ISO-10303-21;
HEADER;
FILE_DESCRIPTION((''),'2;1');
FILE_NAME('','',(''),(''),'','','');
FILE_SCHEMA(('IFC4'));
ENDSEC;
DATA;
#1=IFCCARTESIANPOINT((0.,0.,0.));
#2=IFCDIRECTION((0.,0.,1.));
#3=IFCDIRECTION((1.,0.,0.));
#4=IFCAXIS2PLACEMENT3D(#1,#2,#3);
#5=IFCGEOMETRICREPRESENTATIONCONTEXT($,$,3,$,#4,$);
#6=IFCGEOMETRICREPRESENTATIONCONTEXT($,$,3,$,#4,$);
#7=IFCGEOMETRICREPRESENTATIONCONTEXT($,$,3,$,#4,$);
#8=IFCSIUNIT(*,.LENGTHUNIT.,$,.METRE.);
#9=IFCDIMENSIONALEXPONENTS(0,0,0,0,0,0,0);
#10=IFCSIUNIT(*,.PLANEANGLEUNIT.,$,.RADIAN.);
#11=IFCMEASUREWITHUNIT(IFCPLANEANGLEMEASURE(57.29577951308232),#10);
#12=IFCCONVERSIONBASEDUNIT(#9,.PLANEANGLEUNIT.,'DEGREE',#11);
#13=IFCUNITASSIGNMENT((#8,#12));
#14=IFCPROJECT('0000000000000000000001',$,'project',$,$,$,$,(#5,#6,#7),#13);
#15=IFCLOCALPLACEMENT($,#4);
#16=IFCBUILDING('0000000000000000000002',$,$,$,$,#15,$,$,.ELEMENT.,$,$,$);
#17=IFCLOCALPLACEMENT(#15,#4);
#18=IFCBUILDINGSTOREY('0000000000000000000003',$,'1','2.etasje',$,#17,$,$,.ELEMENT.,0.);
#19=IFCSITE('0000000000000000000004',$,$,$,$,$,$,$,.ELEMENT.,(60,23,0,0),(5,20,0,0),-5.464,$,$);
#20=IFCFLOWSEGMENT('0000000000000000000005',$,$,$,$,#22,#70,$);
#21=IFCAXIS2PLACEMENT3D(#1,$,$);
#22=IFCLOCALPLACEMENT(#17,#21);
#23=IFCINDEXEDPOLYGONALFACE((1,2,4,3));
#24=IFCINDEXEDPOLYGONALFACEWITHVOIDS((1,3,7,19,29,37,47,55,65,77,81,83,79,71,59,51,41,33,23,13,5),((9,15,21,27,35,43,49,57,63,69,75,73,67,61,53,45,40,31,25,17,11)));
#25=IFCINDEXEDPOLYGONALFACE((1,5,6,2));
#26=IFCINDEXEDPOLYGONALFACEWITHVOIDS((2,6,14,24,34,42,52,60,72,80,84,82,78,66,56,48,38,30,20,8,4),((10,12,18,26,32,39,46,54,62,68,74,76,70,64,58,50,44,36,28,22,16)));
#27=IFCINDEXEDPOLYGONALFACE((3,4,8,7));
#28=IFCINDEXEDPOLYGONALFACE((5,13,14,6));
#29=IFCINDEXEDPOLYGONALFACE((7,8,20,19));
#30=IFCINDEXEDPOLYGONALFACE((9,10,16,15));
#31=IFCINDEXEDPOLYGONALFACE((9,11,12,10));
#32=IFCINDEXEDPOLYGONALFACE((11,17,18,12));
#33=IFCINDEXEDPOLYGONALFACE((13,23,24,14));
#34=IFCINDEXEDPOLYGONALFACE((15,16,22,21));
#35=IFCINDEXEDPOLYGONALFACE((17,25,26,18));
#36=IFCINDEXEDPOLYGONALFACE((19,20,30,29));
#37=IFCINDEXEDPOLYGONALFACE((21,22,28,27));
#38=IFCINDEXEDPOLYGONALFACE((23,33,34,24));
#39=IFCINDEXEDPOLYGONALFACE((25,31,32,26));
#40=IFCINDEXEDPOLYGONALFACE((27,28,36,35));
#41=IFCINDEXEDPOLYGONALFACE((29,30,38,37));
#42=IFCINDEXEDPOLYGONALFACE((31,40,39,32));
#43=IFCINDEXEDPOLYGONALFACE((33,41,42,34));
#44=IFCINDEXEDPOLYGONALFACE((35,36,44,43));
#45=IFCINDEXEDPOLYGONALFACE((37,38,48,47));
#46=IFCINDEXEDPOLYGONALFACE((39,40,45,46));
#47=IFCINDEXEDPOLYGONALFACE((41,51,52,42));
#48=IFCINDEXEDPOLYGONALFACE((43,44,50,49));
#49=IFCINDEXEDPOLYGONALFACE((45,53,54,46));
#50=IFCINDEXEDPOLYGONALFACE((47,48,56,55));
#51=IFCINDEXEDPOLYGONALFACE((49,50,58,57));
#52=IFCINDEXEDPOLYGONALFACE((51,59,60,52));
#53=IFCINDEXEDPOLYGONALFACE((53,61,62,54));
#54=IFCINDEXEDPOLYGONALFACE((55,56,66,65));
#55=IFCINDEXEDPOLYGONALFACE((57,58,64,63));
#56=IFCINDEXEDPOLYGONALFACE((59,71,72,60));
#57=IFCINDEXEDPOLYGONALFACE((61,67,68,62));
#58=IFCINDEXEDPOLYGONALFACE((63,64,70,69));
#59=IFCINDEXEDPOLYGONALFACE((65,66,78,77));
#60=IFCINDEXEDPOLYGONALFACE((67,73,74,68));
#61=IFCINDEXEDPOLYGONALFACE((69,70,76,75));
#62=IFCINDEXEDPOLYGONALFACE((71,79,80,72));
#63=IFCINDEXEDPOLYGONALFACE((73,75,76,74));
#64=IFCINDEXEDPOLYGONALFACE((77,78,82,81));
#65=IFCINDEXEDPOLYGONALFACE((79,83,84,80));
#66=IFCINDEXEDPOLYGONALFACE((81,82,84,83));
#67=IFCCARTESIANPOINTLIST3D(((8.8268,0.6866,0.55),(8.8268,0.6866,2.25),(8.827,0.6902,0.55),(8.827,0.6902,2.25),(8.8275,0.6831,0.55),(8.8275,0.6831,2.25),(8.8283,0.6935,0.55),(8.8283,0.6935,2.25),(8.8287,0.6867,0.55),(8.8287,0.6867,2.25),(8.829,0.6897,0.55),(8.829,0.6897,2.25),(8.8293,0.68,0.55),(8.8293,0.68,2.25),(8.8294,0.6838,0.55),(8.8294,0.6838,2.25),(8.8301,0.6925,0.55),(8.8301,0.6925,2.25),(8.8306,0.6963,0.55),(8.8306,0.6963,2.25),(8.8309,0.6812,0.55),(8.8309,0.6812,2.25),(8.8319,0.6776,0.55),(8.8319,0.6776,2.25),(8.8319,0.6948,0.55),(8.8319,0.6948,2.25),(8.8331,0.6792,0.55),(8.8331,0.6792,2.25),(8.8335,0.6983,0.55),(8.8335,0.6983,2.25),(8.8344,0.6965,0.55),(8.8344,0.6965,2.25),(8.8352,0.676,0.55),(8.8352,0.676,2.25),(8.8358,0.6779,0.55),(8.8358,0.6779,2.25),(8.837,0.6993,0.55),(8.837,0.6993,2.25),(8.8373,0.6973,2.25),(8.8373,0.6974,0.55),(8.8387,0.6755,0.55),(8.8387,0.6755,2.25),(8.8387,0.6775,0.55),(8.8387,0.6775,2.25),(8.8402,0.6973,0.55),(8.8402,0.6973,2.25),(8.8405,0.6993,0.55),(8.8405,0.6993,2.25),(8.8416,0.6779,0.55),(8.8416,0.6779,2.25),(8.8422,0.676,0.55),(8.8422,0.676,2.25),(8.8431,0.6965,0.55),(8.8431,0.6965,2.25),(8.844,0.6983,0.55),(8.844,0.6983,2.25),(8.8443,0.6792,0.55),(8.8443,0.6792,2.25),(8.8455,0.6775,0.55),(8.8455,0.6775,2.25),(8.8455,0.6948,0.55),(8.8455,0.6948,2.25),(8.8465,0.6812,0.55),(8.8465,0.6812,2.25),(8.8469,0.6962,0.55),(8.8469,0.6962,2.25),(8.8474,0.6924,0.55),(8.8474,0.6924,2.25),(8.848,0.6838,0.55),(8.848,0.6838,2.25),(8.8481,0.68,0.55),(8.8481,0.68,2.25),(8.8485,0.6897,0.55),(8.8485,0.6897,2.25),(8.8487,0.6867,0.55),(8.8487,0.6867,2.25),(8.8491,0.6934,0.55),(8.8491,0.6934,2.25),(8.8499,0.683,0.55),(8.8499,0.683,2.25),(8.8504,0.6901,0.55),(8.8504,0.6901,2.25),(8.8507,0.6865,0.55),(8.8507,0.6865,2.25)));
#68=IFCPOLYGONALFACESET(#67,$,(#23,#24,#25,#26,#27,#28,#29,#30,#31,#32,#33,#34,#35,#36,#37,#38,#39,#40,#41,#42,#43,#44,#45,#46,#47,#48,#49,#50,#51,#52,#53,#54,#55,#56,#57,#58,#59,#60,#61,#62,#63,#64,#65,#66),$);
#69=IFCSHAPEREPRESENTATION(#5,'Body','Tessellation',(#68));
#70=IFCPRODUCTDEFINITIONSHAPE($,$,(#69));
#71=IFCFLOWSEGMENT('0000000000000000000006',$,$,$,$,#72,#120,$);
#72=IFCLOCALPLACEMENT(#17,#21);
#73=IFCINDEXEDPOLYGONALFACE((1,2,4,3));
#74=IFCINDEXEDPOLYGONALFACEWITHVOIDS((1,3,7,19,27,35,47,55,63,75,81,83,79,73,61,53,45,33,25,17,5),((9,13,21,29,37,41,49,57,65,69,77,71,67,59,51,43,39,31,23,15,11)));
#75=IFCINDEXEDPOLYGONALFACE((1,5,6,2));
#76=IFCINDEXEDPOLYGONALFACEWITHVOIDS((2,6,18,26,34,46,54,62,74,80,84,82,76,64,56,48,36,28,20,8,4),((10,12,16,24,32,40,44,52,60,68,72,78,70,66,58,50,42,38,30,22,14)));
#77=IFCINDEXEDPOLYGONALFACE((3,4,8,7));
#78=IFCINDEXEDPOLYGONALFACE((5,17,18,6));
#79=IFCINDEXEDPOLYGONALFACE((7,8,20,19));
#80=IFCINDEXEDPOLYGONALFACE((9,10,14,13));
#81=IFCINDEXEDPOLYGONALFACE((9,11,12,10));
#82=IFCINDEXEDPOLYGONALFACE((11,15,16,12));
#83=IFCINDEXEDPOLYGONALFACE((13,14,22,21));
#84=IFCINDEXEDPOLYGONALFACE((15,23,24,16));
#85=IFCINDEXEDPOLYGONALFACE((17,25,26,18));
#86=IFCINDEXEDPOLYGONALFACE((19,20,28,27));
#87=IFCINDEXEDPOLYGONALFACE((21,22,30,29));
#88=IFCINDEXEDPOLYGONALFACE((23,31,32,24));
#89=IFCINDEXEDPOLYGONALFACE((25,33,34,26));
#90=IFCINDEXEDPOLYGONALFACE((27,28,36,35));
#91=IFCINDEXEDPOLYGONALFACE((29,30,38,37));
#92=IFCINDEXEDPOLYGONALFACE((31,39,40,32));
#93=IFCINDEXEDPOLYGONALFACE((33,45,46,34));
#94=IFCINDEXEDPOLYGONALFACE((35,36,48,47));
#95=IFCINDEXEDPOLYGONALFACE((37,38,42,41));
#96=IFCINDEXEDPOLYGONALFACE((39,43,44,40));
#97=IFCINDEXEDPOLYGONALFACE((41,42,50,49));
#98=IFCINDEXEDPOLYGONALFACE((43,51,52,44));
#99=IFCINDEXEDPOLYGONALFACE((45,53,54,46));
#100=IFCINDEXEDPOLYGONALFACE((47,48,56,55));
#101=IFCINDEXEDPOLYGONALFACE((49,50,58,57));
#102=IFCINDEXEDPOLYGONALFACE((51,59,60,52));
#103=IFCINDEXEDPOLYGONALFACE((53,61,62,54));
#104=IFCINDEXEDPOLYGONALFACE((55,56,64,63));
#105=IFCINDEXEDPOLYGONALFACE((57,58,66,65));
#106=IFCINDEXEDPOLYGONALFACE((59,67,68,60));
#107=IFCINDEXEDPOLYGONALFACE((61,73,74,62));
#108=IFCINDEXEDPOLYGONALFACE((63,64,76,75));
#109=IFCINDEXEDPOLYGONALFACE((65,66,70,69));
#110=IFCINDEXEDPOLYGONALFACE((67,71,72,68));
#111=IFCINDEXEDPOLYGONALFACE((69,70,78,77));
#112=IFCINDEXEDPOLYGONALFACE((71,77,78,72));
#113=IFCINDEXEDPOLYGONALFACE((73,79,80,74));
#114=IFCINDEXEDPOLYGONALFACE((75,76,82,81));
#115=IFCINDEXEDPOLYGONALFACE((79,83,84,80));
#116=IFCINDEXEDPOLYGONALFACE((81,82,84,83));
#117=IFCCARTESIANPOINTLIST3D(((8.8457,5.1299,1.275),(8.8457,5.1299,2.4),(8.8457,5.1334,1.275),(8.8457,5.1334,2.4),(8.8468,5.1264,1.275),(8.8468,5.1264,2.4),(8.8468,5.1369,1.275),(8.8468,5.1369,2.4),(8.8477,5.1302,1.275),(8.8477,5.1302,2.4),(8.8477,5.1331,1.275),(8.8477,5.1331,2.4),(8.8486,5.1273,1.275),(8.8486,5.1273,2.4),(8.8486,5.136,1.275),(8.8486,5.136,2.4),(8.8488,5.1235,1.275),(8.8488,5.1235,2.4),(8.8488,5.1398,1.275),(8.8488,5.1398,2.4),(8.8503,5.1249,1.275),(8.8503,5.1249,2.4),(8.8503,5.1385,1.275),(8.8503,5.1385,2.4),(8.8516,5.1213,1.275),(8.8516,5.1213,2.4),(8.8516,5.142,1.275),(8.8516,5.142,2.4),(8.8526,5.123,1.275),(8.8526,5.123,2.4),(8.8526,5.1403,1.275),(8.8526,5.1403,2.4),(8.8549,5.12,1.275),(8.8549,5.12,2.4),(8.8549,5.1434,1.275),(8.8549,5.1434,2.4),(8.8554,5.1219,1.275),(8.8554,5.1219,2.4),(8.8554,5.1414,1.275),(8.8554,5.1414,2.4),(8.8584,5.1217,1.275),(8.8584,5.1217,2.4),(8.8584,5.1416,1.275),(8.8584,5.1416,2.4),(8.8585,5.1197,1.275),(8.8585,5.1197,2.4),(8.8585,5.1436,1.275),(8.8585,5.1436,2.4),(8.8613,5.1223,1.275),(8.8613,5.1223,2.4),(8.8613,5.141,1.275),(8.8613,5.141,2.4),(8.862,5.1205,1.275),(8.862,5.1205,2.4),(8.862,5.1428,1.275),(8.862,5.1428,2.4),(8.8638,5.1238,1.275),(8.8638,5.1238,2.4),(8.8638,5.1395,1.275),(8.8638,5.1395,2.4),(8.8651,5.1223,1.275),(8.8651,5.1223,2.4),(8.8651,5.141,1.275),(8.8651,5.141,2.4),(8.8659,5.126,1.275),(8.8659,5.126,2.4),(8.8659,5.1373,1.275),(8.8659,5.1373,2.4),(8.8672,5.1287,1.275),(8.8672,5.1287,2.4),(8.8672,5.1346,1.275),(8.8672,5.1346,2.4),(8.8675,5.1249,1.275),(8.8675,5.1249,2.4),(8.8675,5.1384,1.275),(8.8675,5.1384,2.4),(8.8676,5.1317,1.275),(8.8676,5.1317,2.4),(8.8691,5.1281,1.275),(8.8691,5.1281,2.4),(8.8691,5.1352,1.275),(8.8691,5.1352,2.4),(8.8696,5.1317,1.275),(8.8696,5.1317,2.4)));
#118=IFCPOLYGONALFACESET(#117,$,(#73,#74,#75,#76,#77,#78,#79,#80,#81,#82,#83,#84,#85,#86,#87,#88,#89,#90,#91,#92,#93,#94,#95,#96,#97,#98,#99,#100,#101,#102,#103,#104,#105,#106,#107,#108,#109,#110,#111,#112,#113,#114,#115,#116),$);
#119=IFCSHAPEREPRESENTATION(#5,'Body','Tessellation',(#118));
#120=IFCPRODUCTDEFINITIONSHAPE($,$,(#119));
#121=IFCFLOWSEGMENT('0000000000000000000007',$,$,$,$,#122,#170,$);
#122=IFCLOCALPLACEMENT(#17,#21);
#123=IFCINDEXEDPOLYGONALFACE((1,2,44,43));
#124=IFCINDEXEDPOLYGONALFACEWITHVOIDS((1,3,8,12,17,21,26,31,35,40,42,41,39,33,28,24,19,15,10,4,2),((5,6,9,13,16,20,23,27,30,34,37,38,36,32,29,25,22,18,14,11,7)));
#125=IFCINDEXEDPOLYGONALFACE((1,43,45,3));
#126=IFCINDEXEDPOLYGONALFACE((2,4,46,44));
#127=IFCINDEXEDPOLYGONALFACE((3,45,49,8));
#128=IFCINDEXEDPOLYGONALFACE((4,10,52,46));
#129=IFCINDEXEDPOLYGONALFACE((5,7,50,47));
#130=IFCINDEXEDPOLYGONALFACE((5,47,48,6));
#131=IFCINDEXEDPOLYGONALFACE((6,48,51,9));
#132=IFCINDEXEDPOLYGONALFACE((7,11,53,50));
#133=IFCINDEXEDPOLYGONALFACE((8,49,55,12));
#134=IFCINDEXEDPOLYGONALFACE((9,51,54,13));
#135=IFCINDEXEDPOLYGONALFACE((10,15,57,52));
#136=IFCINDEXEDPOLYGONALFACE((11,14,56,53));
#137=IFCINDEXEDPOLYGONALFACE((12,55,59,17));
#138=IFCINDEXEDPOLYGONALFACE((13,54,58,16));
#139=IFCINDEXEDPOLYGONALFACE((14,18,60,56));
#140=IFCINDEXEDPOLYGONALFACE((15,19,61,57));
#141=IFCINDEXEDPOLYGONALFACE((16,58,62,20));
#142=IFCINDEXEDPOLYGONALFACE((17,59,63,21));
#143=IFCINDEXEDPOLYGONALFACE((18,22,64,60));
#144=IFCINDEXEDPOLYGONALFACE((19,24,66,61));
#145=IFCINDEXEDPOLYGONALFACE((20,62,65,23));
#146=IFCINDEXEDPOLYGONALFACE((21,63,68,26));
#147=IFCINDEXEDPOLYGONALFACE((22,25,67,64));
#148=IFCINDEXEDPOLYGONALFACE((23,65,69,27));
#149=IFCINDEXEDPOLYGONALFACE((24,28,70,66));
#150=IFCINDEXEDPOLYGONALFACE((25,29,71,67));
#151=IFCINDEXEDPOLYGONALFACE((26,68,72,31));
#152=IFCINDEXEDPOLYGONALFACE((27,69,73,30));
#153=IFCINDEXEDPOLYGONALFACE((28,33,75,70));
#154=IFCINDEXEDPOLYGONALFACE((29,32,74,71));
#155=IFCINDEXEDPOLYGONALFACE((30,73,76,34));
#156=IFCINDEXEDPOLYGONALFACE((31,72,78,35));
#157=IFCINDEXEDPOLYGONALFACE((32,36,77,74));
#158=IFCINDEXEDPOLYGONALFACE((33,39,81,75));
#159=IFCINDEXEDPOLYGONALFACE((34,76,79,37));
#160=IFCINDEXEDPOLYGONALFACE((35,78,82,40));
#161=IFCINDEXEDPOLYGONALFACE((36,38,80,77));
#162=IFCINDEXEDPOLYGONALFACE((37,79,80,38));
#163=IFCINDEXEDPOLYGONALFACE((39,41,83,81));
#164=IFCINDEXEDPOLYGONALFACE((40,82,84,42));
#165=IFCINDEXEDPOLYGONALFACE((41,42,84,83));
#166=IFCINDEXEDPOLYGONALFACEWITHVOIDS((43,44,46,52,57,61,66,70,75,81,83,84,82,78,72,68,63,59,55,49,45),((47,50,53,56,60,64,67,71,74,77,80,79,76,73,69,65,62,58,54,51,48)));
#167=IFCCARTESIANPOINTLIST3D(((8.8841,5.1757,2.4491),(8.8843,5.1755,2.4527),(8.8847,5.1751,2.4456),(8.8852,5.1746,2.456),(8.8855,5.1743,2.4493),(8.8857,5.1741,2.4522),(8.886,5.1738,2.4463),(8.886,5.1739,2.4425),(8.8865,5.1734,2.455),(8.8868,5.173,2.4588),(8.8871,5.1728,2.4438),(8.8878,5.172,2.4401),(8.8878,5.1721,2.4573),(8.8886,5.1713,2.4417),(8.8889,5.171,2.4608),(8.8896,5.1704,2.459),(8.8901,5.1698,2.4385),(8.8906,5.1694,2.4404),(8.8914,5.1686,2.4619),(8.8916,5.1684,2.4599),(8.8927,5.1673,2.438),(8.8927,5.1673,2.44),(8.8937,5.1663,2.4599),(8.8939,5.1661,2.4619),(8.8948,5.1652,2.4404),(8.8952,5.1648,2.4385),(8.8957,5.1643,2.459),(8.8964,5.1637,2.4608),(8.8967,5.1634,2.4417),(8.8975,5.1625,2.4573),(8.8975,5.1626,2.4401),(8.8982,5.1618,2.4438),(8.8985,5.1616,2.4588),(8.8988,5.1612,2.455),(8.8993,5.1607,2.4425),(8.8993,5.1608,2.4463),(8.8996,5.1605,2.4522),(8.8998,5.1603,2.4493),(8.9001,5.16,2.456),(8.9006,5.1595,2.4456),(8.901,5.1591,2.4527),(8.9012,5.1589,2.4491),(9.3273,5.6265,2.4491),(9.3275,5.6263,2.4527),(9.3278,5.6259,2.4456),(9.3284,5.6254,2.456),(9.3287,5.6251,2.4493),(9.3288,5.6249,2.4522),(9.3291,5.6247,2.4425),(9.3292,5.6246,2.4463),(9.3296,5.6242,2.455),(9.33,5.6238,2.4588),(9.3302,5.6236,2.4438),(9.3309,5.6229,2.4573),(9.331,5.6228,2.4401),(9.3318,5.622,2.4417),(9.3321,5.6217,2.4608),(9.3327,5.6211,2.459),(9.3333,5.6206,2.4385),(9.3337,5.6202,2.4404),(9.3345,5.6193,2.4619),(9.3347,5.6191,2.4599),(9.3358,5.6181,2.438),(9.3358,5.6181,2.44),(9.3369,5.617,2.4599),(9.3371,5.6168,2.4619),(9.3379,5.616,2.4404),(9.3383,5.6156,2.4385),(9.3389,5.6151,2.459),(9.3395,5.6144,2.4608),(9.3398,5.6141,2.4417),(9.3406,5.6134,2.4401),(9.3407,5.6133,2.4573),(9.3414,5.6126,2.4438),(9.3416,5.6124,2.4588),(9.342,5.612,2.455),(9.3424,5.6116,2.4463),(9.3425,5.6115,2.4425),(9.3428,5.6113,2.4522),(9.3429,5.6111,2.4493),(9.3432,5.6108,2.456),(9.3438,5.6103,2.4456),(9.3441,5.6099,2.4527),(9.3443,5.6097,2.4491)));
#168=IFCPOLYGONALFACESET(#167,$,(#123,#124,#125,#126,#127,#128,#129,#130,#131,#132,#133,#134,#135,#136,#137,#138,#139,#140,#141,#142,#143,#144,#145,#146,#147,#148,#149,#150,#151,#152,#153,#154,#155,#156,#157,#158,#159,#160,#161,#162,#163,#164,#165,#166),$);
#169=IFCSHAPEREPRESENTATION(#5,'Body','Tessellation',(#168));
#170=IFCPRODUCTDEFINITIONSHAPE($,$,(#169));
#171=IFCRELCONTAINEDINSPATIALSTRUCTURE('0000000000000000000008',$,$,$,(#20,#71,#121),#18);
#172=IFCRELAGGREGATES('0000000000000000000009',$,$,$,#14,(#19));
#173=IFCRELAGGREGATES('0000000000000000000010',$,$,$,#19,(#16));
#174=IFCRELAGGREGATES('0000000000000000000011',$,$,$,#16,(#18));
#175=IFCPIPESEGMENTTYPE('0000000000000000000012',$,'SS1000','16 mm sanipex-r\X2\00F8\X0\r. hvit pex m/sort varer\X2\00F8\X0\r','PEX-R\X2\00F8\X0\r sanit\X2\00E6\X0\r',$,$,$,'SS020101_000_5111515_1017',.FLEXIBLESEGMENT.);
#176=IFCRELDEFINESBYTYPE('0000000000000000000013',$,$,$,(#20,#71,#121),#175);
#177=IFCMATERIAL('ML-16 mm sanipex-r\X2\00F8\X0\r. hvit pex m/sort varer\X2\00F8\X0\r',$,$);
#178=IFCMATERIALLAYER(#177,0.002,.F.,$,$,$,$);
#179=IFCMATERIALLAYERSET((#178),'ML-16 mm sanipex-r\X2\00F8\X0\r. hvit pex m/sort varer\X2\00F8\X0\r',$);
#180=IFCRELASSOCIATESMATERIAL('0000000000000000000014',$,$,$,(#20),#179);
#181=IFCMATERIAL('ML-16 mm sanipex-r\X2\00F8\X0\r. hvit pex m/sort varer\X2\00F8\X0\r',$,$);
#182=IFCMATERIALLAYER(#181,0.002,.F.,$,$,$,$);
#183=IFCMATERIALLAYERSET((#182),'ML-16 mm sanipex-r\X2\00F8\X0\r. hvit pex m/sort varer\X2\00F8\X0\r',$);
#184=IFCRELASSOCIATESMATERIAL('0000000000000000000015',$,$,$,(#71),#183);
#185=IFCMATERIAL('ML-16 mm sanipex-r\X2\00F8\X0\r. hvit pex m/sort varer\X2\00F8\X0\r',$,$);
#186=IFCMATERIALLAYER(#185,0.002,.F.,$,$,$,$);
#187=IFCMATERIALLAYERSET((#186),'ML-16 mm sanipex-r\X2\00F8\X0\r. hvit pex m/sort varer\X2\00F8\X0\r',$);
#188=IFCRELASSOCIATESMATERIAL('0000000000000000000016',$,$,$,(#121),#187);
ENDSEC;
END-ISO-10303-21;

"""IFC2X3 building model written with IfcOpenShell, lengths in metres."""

from ifc_helpers import new_model, entity, si_unit, converted_unit, frame, origin_with_axes, origin_2d_with_axis, place, context, project, spatial, hollow_circle, extrude, material, layer, layer_set, layer_usage, type_object, element, save


model = new_model("IFC2X3")

# Units and contexts
context_of_model_1 = context(None, 3, world=origin_with_axes())
context_of_model_2 = context(None, 3, world=origin_with_axes())
context_of_model_3 = context(None, 3, world=origin_with_axes())
ifc_project = project(units=[si_unit("LENGTHUNIT", "METRE"), converted_unit("PLANEANGLEUNIT", "DEGREE", entity("IfcPlaneAngleMeasure", 57.29577951308232), si_unit("PLANEANGLEUNIT", "RADIAN"), dimensions=[0, 0, 0, 0, 0, 0, 0])], contexts=[context_of_model_1, context_of_model_2, context_of_model_3])

# Site, building, storey
site = spatial("IfcSite", under=ifc_project, CompositionType="ELEMENT", RefLatitude=(60, 23, 0, 0), RefLongitude=(5, 20, 0, 0), RefElevation=-5.464)
building_placement = place(None, origin_with_axes())
building = spatial("IfcBuilding", under=site, at=building_placement, CompositionType="ELEMENT")
storey_placement = place(building_placement, origin_with_axes())
storey = spatial("IfcBuildingStorey", under=building, at=storey_placement, Name="1", Description="2.etasje", CompositionType="ELEMENT", Elevation=0.0)

# Flow segments
pipe_segment_type_1 = type_object("IfcPipeSegmentType", Name="SS1000", Description="16 mm sanipex-rør. hvit pex m/sort varerør", ApplicableOccurrence="PEX-Rør sanitær", ElementType="SS020101_000_5111515_1017", PredefinedType="FLEXIBLESEGMENT")
ifc_material_1 = material(Name="ML-16 mm sanipex-rør. hvit pex m/sort varerør")
ifc_layer_1 = layer(ifc_material_1, 0.002, ventilated=False)
ifc_layer_set_1 = layer_set([ifc_layer_1], Name="ML-16 mm sanipex-rør. hvit pex m/sort varerør")
ifc_layer_usage_1 = layer_usage(ifc_layer_set_1, "AXIS2", "POSITIVE", 0.0)
flow_segment_1_placement = place(storey_placement, frame((8.8387, 0.6875, 2.25), z_axis=(0.0, 0.0, -1.0), x_axis=(0.151254, 0.988495, 0.0)))
element("IfcFlowSegment", 1, at=flow_segment_1_placement, inside=storey, type_object=pipe_segment_type_1, material=ifc_layer_usage_1, context=context_of_model_1, shape_type="SweptSolid", body=[
    extrude(hollow_circle(Radius=0.012, WallThickness=0.002, at=origin_2d_with_axis()), origin_with_axes(), (0.0, 0.0, 1.0), 1.7),
])
ifc_material_2 = material(Name="ML-16 mm sanipex-rør. hvit pex m/sort varerør")
ifc_layer_2 = layer(ifc_material_2, 0.002, ventilated=False)
ifc_layer_set_2 = layer_set([ifc_layer_2], Name="ML-16 mm sanipex-rør. hvit pex m/sort varerør")
ifc_layer_usage_2 = layer_usage(ifc_layer_set_2, "AXIS2", "POSITIVE", 0.0)
flow_segment_2_placement = place(storey_placement, frame((8.8576, 5.1317, 1.275), z_axis=(0.0, 0.0, 1.0), x_axis=(1.0, 0.0, 0.0)))
element("IfcFlowSegment", 2, at=flow_segment_2_placement, inside=storey, type_object=pipe_segment_type_1, material=ifc_layer_usage_2, context=context_of_model_1, shape_type="SweptSolid", body=[
    extrude(hollow_circle(Radius=0.012, WallThickness=0.002, at=origin_2d_with_axis()), origin_with_axes(), (0.0, 0.0, 1.0), 1.125),
])
ifc_material_3 = material(Name="ML-16 mm sanipex-rør. hvit pex m/sort varerør")
ifc_layer_3 = layer(ifc_material_3, 0.002, ventilated=False)
ifc_layer_set_3 = layer_set([ifc_layer_3], Name="ML-16 mm sanipex-rør. hvit pex m/sort varerør")
ifc_layer_usage_3 = layer_usage(ifc_layer_set_3, "AXIS2", "POSITIVE", 0.0)
flow_segment_3_placement = place(storey_placement, frame((8.8927, 5.1673, 2.45), z_axis=(0.70104, 0.713121, 0.0), x_axis=(0.0, 0.0, -1.0)))
element("IfcFlowSegment", 3, at=flow_segment_3_placement, inside=storey, type_object=pipe_segment_type_1, material=ifc_layer_usage_3, context=context_of_model_1, shape_type="SweptSolid", body=[
    extrude(hollow_circle(Radius=0.012, WallThickness=0.002, at=origin_2d_with_axis()), origin_with_axes(), (0.0, 0.0, 1.0), 0.6321),
])

save(model, "model.ifc")
